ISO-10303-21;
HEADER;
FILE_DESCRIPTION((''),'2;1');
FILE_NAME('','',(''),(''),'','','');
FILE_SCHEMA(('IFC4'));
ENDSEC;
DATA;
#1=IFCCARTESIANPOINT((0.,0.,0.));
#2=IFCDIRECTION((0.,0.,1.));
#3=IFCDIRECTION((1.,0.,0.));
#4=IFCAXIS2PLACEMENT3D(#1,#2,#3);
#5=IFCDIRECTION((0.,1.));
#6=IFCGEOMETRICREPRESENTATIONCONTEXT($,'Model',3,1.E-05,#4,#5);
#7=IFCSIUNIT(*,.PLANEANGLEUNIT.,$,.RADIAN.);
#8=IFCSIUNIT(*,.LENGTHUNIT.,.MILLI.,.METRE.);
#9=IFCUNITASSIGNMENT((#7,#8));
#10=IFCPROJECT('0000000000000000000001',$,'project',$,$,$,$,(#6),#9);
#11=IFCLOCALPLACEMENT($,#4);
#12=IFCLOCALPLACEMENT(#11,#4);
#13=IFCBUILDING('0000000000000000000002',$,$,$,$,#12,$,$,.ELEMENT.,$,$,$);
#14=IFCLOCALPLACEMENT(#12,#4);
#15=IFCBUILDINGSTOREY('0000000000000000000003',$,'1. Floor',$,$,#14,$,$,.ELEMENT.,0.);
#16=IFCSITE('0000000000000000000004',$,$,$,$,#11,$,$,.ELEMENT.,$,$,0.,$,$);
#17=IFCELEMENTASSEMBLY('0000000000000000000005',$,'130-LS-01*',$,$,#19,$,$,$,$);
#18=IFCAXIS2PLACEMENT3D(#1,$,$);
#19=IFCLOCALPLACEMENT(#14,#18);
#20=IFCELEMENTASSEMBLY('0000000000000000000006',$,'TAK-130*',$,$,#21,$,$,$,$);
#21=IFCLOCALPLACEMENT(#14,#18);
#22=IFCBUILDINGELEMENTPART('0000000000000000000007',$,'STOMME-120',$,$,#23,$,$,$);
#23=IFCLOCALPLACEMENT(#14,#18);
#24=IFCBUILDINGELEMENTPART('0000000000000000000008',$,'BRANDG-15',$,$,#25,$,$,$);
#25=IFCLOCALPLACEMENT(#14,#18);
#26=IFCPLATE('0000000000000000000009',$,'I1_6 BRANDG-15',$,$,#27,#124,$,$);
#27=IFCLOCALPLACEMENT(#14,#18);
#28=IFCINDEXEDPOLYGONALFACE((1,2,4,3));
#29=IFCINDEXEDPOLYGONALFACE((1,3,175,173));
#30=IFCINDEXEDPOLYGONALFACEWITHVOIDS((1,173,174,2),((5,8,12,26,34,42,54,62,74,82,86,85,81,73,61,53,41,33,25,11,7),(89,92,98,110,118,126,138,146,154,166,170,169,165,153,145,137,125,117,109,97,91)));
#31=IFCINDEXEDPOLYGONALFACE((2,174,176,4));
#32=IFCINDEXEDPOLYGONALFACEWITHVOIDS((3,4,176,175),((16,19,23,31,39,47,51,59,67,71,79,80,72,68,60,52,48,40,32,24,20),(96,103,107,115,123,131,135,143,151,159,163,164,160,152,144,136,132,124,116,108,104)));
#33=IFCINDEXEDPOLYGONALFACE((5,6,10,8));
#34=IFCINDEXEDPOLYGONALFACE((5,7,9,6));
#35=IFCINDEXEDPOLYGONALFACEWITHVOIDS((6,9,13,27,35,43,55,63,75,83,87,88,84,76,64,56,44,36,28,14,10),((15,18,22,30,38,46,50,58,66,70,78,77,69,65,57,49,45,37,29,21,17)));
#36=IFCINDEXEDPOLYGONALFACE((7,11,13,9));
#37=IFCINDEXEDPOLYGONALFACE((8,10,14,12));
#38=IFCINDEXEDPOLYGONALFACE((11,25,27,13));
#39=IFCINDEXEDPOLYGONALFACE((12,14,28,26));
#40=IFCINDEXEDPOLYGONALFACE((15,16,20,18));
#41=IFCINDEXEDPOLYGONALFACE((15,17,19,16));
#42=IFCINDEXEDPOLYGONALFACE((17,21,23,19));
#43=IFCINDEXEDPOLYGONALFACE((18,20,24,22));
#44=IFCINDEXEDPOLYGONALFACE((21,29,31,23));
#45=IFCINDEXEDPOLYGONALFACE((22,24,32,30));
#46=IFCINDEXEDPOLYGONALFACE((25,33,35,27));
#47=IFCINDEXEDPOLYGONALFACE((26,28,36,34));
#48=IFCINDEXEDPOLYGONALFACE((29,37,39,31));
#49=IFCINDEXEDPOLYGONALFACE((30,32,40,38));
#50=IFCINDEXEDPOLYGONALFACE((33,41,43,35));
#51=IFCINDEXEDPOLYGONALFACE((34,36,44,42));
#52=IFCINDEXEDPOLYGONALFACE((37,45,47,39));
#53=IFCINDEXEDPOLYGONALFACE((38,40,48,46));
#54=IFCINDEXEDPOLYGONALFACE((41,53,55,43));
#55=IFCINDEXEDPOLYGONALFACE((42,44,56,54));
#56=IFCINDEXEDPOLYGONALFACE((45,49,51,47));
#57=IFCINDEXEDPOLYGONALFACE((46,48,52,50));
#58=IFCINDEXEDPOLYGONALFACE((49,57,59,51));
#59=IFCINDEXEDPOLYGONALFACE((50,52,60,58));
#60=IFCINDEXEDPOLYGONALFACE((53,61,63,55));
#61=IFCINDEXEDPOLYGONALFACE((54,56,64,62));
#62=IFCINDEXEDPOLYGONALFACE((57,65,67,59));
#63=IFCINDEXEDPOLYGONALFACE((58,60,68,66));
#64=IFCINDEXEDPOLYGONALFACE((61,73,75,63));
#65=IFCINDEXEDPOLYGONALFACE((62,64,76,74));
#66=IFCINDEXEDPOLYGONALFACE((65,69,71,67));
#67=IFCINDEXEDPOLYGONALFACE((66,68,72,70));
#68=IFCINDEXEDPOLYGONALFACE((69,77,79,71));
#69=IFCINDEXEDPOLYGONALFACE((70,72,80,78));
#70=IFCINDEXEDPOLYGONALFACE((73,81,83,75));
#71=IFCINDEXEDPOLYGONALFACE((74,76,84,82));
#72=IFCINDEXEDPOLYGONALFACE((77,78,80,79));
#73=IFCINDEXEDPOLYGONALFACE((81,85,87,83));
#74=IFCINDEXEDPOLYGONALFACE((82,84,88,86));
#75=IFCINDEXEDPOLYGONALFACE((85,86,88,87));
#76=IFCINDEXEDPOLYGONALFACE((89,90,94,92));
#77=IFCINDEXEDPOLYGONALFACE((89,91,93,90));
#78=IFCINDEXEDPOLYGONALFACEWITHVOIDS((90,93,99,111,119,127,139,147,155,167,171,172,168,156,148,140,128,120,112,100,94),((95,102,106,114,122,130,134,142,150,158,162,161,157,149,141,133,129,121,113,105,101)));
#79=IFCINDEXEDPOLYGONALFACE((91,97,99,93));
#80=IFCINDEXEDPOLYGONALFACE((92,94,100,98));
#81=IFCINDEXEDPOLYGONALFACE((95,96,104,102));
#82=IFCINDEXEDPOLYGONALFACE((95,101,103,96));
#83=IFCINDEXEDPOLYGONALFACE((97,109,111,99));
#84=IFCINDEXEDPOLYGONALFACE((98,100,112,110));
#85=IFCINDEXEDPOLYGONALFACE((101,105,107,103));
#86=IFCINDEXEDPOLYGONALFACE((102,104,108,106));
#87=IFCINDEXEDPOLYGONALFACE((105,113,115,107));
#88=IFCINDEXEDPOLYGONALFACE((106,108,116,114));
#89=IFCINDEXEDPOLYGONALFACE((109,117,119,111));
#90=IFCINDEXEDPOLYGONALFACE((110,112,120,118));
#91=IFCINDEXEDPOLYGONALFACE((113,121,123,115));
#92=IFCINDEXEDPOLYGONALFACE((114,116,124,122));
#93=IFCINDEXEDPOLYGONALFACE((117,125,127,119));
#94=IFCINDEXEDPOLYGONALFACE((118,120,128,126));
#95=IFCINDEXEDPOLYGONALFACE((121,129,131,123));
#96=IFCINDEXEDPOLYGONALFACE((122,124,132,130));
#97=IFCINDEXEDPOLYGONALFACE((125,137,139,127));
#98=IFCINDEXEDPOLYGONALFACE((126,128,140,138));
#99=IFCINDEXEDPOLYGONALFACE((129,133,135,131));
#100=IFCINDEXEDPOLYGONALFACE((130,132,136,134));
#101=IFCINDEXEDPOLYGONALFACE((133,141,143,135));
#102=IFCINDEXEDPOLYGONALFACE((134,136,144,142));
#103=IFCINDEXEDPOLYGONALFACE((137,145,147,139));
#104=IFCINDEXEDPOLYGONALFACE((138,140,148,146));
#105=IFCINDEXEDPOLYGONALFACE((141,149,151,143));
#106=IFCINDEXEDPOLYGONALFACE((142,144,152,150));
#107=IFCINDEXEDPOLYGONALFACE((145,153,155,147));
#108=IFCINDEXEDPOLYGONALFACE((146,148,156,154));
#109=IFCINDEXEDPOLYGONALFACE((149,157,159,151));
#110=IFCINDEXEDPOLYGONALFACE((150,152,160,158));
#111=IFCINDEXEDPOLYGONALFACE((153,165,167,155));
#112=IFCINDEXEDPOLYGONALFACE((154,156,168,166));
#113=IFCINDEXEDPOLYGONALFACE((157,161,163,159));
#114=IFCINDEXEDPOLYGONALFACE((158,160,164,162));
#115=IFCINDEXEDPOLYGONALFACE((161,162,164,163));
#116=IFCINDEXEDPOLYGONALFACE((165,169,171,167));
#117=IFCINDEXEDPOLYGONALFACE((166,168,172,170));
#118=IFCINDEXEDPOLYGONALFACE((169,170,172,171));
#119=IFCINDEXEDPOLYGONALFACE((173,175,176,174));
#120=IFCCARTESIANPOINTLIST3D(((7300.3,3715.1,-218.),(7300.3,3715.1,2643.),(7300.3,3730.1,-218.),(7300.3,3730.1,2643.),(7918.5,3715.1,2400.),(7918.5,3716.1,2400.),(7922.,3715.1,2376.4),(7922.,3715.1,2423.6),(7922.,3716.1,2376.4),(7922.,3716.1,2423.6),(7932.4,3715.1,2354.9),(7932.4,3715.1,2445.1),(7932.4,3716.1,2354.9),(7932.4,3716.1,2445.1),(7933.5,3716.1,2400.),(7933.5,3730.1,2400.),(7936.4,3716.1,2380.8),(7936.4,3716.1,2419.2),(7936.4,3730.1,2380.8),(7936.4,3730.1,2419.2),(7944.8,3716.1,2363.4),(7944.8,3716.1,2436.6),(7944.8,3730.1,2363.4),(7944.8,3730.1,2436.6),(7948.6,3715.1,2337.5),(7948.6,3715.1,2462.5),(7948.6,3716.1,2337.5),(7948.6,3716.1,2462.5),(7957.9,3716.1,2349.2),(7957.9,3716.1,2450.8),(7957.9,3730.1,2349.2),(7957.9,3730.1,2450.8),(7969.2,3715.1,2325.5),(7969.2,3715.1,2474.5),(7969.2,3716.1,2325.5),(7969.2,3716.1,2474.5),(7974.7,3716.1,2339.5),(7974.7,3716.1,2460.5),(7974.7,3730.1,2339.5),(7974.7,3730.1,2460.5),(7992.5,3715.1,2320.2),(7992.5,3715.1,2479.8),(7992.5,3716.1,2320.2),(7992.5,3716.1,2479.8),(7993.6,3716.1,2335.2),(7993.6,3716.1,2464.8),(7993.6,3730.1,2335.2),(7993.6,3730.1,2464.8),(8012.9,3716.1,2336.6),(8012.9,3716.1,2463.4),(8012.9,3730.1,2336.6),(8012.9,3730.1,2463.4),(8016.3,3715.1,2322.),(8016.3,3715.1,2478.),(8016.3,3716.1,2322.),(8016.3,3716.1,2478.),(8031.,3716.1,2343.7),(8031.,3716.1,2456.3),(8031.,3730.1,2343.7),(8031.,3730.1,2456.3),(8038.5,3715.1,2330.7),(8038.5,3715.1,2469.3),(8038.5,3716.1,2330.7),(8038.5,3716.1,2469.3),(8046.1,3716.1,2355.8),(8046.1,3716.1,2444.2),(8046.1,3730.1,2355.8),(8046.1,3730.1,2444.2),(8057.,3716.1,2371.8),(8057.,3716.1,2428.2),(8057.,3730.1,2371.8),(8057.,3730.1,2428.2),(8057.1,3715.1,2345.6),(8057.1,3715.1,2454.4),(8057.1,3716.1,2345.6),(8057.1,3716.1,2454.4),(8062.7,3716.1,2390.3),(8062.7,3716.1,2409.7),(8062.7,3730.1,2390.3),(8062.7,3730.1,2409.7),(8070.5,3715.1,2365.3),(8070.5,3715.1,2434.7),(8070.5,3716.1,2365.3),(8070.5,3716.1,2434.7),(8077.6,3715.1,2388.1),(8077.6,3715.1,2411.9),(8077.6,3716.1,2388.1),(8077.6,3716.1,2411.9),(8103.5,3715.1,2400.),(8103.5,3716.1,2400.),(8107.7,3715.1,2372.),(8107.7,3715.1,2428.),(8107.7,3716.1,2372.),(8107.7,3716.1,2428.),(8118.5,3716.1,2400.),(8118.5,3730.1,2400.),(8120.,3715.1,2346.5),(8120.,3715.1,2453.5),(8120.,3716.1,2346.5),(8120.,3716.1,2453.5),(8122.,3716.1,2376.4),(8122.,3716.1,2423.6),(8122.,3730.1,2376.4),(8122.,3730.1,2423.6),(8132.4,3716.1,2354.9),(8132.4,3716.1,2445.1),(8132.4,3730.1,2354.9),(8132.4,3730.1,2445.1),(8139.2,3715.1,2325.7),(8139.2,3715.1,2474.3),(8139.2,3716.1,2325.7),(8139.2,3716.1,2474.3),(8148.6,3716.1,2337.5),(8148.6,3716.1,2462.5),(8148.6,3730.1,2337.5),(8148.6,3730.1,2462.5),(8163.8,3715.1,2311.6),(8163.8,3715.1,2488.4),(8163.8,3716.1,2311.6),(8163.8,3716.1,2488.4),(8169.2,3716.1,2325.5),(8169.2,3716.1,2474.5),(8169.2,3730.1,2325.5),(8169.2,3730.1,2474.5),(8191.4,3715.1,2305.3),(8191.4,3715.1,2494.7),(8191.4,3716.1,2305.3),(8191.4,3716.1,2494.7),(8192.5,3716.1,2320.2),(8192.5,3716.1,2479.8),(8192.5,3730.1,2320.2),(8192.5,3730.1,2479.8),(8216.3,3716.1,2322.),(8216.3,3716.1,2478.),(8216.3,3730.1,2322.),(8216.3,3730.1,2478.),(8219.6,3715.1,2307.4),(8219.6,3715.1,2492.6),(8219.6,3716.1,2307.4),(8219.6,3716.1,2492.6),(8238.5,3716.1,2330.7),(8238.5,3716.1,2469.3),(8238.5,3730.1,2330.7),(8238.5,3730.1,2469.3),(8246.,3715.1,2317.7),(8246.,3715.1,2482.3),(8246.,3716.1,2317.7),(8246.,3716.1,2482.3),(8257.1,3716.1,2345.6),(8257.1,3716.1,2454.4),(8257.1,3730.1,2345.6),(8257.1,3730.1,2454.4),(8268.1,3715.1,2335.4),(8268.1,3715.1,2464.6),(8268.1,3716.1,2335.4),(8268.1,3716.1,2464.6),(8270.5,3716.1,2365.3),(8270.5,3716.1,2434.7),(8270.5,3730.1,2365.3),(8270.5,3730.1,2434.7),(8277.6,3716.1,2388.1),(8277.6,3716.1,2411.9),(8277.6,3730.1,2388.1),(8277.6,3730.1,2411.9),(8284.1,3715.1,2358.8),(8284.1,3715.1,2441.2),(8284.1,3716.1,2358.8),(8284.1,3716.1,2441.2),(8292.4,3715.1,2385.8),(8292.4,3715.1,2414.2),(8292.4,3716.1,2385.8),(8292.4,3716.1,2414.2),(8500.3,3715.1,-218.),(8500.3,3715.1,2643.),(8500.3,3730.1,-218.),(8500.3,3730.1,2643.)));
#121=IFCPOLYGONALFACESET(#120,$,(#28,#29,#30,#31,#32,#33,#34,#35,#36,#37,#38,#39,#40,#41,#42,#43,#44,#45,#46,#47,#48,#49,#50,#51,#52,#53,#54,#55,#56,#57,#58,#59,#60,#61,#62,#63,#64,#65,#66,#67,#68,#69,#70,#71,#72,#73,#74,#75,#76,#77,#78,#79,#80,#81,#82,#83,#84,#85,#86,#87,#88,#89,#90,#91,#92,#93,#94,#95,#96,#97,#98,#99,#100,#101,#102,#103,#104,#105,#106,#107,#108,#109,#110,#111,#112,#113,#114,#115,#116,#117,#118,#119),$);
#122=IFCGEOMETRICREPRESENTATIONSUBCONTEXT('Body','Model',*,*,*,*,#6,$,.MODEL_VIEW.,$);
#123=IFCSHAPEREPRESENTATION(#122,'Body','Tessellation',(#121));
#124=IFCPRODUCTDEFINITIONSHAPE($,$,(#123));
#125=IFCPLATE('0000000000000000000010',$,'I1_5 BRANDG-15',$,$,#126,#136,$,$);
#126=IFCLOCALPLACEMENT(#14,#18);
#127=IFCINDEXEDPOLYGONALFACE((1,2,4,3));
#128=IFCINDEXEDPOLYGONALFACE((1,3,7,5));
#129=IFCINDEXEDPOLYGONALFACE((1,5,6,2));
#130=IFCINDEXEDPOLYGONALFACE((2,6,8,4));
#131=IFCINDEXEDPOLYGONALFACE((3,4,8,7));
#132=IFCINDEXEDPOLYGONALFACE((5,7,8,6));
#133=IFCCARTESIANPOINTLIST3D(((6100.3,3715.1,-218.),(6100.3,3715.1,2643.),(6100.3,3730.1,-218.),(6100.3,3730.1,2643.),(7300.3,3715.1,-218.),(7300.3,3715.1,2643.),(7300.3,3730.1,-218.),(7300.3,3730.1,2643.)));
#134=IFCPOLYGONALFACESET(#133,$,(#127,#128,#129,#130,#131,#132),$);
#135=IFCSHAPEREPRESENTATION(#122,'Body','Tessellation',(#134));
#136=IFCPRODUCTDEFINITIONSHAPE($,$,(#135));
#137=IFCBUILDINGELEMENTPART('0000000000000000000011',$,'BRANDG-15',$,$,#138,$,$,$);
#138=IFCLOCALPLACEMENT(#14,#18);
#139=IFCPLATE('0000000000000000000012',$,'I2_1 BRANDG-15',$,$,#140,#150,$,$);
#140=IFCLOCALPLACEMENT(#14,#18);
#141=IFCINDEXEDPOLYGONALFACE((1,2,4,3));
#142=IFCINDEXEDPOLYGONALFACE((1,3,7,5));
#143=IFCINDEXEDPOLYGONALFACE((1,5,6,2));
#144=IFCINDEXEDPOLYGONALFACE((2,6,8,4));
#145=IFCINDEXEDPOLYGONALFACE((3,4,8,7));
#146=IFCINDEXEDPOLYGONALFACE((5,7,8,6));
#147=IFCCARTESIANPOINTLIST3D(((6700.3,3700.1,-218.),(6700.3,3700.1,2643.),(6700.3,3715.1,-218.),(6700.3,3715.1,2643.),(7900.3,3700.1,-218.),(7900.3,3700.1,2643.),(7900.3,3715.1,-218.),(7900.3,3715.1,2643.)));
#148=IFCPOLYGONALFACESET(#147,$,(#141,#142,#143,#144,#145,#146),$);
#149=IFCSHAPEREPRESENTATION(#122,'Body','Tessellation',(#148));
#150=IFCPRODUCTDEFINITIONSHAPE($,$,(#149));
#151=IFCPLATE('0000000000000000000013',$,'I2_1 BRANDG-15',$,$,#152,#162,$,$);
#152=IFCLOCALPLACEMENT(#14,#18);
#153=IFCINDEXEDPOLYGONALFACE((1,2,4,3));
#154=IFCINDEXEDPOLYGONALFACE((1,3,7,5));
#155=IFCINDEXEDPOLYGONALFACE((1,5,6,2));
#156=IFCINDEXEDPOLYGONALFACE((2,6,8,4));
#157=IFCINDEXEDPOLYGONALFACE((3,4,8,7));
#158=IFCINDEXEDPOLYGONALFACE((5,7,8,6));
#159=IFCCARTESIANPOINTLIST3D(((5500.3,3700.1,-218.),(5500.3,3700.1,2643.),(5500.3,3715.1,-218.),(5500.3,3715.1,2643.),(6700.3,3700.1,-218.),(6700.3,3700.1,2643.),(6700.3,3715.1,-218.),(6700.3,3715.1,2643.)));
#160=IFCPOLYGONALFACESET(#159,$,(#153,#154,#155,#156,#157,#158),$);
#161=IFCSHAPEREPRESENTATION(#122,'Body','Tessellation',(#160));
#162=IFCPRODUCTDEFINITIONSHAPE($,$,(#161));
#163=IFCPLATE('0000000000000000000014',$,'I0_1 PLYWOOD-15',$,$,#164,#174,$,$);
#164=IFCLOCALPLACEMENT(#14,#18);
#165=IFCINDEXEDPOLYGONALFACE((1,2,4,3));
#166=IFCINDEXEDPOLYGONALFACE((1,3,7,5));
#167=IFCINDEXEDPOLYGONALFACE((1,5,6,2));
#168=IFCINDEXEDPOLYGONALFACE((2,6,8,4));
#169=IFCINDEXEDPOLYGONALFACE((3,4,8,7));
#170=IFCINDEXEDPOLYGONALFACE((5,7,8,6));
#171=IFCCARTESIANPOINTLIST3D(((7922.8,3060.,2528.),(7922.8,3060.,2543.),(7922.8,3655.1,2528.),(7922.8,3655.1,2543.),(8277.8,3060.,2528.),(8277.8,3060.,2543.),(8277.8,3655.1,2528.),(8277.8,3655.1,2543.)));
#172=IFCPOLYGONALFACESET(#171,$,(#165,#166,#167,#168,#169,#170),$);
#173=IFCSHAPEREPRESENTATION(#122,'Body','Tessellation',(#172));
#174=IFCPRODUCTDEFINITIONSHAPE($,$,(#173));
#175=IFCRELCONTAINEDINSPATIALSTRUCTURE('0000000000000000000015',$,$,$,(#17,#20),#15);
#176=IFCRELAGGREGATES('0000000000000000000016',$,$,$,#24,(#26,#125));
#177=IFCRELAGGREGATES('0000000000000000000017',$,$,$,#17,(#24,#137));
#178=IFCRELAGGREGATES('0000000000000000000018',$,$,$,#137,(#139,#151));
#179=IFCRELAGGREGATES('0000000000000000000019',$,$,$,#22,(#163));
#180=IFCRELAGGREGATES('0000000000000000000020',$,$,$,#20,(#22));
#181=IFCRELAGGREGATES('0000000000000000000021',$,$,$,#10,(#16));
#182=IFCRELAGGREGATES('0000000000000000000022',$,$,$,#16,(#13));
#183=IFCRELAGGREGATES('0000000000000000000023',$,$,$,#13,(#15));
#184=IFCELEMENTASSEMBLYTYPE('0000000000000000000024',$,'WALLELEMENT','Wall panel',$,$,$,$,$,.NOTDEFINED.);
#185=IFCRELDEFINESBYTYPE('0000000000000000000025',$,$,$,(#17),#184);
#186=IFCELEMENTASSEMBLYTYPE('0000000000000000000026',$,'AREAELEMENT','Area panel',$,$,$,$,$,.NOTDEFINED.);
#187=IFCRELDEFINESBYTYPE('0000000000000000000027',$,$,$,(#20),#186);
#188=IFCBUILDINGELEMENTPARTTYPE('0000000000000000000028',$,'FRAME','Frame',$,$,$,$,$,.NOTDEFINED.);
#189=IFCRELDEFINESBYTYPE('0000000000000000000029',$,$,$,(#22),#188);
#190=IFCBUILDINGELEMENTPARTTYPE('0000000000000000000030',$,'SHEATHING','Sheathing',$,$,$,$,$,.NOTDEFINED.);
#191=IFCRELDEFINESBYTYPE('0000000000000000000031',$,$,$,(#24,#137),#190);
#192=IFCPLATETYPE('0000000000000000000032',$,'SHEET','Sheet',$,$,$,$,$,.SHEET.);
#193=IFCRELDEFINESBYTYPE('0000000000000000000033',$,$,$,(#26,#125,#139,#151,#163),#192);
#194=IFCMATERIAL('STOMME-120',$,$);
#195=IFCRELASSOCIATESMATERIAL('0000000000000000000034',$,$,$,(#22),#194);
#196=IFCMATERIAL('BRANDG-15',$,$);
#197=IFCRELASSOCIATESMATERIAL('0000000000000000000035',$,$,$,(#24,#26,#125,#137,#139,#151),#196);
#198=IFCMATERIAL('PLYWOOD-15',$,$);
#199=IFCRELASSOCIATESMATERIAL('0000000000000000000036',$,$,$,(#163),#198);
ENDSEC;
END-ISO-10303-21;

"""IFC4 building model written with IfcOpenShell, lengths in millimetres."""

from ifc_helpers import new_model, si_unit, direction, frame, origin_with_axes, origin_2d_with_axis, place, context, subcontext, project, spatial, rectangle, circle, extrude, boolean, material, type_object, element, aggregate, save


model = new_model("IFC4")

# Units and contexts
model_context = context("Model", 3, precision=1e-05, world=origin_with_axes(), true_north=direction((0.0, 1.0)))
body_context = subcontext(model_context, "Body", "Model", "MODEL_VIEW")
ifc_project = project(units=[si_unit("PLANEANGLEUNIT", "RADIAN"), si_unit("LENGTHUNIT", "METRE", prefix="MILLI")], contexts=[model_context])

# Site, building, storey
site_placement = place(None, origin_with_axes())
site = spatial("IfcSite", under=ifc_project, at=site_placement, CompositionType="ELEMENT", RefElevation=0.0)
building_placement = place(site_placement, origin_with_axes())
building = spatial("IfcBuilding", under=site, at=building_placement, CompositionType="ELEMENT")
storey_placement = place(building_placement, origin_with_axes())
storey = spatial("IfcBuildingStorey", under=building, at=storey_placement, Name="1. Floor", CompositionType="ELEMENT", Elevation=0.0)

# Element assembly
element_assembly_type_1 = type_object("IfcElementAssemblyType", Name="WALLELEMENT", Description="Wall panel", PredefinedType="NOTDEFINED")
assembly_1_placement = place(storey_placement, origin_with_axes())
assembly_1 = element("IfcElementAssembly", 1, at=assembly_1_placement, inside=storey, type_object=element_assembly_type_1, Name="130-LS-01*")
building_element_part_type_1 = type_object("IfcBuildingElementPartType", Name="FRAME", Description="Frame", PredefinedType="NOTDEFINED")

# Element assembly, building element part
element_assembly_type_2 = type_object("IfcElementAssemblyType", Name="AREAELEMENT", Description="Area panel", PredefinedType="NOTDEFINED")
assembly_2_placement = place(storey_placement, origin_with_axes())
assembly_2 = element("IfcElementAssembly", 2, at=assembly_2_placement, inside=storey, type_object=element_assembly_type_2, Name="TAK-130*")
ifc_material_1 = material(Name="STOMME-120")
building_element_part_1_placement = place(storey_placement, origin_with_axes())
building_element_part_1 = element("IfcBuildingElementPart", 3, at=building_element_part_1_placement, type_object=building_element_part_type_1, material=ifc_material_1, Name="STOMME-120")

# Building element part, plates
ifc_material_2 = material(Name="BRANDG-15")
building_element_part_type_2 = type_object("IfcBuildingElementPartType", Name="SHEATHING", Description="Sheathing", PredefinedType="NOTDEFINED")
building_element_part_2_placement = place(storey_placement, origin_with_axes())
building_element_part_2 = element("IfcBuildingElementPart", 4, at=building_element_part_2_placement, type_object=building_element_part_type_2, material=ifc_material_2, Name="BRANDG-15")
plate_type = type_object("IfcPlateType", Name="SHEET", Description="Sheet", PredefinedType="SHEET")
plate_1_placement = place(storey_placement, frame((7900.3, 3730.1, 4782.0), z_axis=(0.0, 1.0, 0.0), x_axis=(-1.0, 0.0, 0.0)))
plate_1 = element("IfcPlate", 5, at=plate_1_placement, type_object=plate_type, material=ifc_material_2, Name="I1_6 BRANDG-15", context=body_context, shape_type="CSG", body=[
    boolean("DIFFERENCE", boolean("DIFFERENCE", boolean("DIFFERENCE", boolean("DIFFERENCE", boolean("DIFFERENCE", boolean("DIFFERENCE", extrude(rectangle(XDim=15.0, YDim=1200.0, at=origin_2d_with_axis()), frame((0.0, -5000.0, -7.5), z_axis=(0.0, 1.0, 0.0), x_axis=(0.0, 0.0, 1.0)), (0.0, 0.0, 1.0), 2861.0), extrude(circle(Radius=80.0, at=origin_2d_with_axis()), frame((-298.2, -2382.0, -31.0), z_axis=(0.0, 0.0, -1.0), x_axis=(1.0, 0.0, 0.0)), (0.0, 0.0, -1.0), 64.5)), extrude(circle(Radius=65.0, at=origin_2d_with_axis()), frame((-98.2, -2382.0, -31.0), z_axis=(0.0, 0.0, -1.0), x_axis=(1.0, 0.0, 0.0)), (0.0, 0.0, -1.0), 64.5)), extrude(circle(Radius=80.0, at=origin_2d_with_axis()), frame((-98.2, -2382.0, -31.0), z_axis=(0.0, 0.0, -1.0), x_axis=(1.0, 0.0, 0.0)), (0.0, 0.0, -1.0), 17.0)), extrude(circle(Radius=65.0, at=origin_2d_with_axis()), frame((-98.2, -2382.0, -31.0), z_axis=(0.0, 0.0, -1.0), x_axis=(1.0, 0.0, 0.0)), (0.0, 0.0, -1.0), 64.5)), extrude(circle(Radius=80.0, at=origin_2d_with_axis()), frame((-298.2, -2382.0, -31.0), z_axis=(0.0, 0.0, -1.0), x_axis=(1.0, 0.0, 0.0)), (0.0, 0.0, -1.0), 64.5)), extrude(circle(Radius=95.0, at=origin_2d_with_axis()), frame((-298.2, -2382.0, -31.0), z_axis=(0.0, 0.0, -1.0), x_axis=(1.0, 0.0, 0.0)), (0.0, 0.0, -1.0), 17.0)),
])
plate_2_placement = place(storey_placement, frame((6700.3, 3730.1, 4782.0), z_axis=(0.0, 1.0, 0.0), x_axis=(-1.0, 0.0, 0.0)))
plate_2 = element("IfcPlate", 6, at=plate_2_placement, type_object=plate_type, material=ifc_material_2, Name="I1_5 BRANDG-15", context=body_context, shape_type="SweptSolid", body=[
    extrude(rectangle(XDim=15.0, YDim=1200.0, at=origin_2d_with_axis()), frame((0.0, -5000.0, -7.5), z_axis=(0.0, 1.0, 0.0), x_axis=(0.0, 0.0, 1.0)), (0.0, 0.0, 1.0), 2861.0),
])
aggregate(building_element_part_2, [plate_1, plate_2])

# Building element part
building_element_part_3_placement = place(storey_placement, origin_with_axes())
building_element_part_3 = element("IfcBuildingElementPart", 7, at=building_element_part_3_placement, type_object=building_element_part_type_2, material=ifc_material_2, Name="BRANDG-15")
aggregate(assembly_1, [building_element_part_2, building_element_part_3])

# Plates
plate_3_placement = place(storey_placement, frame((7300.3, 3715.1, 4782.0), z_axis=(0.0, 1.0, 0.0), x_axis=(-1.0, 0.0, 0.0)))
plate_3 = element("IfcPlate", 8, at=plate_3_placement, type_object=plate_type, material=ifc_material_2, Name="I2_1 BRANDG-15", context=body_context, shape_type="SweptSolid", body=[
    extrude(rectangle(XDim=15.0, YDim=1200.0, at=origin_2d_with_axis()), frame((0.0, -5000.0, -7.5), z_axis=(0.0, 1.0, 0.0), x_axis=(0.0, 0.0, 1.0)), (0.0, 0.0, 1.0), 2861.0),
])
plate_4_placement = place(storey_placement, frame((6100.3, 3715.1, 4782.0), z_axis=(0.0, 1.0, 0.0), x_axis=(-1.0, 0.0, 0.0)))
plate_4 = element("IfcPlate", 9, at=plate_4_placement, type_object=plate_type, material=ifc_material_2, Name="I2_1 BRANDG-15", context=body_context, shape_type="SweptSolid", body=[
    extrude(rectangle(XDim=15.0, YDim=1200.0, at=origin_2d_with_axis()), frame((0.0, -5000.0, -7.5), z_axis=(0.0, 1.0, 0.0), x_axis=(0.0, 0.0, 1.0)), (0.0, 0.0, 1.0), 2861.0),
])
aggregate(building_element_part_3, [plate_3, plate_4])
ifc_material_3 = material(Name="PLYWOOD-15")
plate_5_placement = place(storey_placement, frame((7922.8, 1765.1, 2543.0), z_axis=(0.0, 0.0, 1.0), x_axis=(1.0, 0.0, 0.0)))
plate_5 = element("IfcPlate", 10, at=plate_5_placement, type_object=plate_type, material=ifc_material_3, Name="I0_1 PLYWOOD-15", context=body_context, shape_type="SweptSolid", body=[
    extrude(rectangle(XDim=15.0, YDim=355.0, at=origin_2d_with_axis()), frame((177.5, 1294.9, -7.5), z_axis=(0.0, 1.0, 0.0), x_axis=(0.0, 0.0, 1.0)), (0.0, 0.0, 1.0), 595.1),
])
aggregate(building_element_part_1, [plate_5])

aggregate(assembly_2, [building_element_part_1])

save(model, "model.ifc")
